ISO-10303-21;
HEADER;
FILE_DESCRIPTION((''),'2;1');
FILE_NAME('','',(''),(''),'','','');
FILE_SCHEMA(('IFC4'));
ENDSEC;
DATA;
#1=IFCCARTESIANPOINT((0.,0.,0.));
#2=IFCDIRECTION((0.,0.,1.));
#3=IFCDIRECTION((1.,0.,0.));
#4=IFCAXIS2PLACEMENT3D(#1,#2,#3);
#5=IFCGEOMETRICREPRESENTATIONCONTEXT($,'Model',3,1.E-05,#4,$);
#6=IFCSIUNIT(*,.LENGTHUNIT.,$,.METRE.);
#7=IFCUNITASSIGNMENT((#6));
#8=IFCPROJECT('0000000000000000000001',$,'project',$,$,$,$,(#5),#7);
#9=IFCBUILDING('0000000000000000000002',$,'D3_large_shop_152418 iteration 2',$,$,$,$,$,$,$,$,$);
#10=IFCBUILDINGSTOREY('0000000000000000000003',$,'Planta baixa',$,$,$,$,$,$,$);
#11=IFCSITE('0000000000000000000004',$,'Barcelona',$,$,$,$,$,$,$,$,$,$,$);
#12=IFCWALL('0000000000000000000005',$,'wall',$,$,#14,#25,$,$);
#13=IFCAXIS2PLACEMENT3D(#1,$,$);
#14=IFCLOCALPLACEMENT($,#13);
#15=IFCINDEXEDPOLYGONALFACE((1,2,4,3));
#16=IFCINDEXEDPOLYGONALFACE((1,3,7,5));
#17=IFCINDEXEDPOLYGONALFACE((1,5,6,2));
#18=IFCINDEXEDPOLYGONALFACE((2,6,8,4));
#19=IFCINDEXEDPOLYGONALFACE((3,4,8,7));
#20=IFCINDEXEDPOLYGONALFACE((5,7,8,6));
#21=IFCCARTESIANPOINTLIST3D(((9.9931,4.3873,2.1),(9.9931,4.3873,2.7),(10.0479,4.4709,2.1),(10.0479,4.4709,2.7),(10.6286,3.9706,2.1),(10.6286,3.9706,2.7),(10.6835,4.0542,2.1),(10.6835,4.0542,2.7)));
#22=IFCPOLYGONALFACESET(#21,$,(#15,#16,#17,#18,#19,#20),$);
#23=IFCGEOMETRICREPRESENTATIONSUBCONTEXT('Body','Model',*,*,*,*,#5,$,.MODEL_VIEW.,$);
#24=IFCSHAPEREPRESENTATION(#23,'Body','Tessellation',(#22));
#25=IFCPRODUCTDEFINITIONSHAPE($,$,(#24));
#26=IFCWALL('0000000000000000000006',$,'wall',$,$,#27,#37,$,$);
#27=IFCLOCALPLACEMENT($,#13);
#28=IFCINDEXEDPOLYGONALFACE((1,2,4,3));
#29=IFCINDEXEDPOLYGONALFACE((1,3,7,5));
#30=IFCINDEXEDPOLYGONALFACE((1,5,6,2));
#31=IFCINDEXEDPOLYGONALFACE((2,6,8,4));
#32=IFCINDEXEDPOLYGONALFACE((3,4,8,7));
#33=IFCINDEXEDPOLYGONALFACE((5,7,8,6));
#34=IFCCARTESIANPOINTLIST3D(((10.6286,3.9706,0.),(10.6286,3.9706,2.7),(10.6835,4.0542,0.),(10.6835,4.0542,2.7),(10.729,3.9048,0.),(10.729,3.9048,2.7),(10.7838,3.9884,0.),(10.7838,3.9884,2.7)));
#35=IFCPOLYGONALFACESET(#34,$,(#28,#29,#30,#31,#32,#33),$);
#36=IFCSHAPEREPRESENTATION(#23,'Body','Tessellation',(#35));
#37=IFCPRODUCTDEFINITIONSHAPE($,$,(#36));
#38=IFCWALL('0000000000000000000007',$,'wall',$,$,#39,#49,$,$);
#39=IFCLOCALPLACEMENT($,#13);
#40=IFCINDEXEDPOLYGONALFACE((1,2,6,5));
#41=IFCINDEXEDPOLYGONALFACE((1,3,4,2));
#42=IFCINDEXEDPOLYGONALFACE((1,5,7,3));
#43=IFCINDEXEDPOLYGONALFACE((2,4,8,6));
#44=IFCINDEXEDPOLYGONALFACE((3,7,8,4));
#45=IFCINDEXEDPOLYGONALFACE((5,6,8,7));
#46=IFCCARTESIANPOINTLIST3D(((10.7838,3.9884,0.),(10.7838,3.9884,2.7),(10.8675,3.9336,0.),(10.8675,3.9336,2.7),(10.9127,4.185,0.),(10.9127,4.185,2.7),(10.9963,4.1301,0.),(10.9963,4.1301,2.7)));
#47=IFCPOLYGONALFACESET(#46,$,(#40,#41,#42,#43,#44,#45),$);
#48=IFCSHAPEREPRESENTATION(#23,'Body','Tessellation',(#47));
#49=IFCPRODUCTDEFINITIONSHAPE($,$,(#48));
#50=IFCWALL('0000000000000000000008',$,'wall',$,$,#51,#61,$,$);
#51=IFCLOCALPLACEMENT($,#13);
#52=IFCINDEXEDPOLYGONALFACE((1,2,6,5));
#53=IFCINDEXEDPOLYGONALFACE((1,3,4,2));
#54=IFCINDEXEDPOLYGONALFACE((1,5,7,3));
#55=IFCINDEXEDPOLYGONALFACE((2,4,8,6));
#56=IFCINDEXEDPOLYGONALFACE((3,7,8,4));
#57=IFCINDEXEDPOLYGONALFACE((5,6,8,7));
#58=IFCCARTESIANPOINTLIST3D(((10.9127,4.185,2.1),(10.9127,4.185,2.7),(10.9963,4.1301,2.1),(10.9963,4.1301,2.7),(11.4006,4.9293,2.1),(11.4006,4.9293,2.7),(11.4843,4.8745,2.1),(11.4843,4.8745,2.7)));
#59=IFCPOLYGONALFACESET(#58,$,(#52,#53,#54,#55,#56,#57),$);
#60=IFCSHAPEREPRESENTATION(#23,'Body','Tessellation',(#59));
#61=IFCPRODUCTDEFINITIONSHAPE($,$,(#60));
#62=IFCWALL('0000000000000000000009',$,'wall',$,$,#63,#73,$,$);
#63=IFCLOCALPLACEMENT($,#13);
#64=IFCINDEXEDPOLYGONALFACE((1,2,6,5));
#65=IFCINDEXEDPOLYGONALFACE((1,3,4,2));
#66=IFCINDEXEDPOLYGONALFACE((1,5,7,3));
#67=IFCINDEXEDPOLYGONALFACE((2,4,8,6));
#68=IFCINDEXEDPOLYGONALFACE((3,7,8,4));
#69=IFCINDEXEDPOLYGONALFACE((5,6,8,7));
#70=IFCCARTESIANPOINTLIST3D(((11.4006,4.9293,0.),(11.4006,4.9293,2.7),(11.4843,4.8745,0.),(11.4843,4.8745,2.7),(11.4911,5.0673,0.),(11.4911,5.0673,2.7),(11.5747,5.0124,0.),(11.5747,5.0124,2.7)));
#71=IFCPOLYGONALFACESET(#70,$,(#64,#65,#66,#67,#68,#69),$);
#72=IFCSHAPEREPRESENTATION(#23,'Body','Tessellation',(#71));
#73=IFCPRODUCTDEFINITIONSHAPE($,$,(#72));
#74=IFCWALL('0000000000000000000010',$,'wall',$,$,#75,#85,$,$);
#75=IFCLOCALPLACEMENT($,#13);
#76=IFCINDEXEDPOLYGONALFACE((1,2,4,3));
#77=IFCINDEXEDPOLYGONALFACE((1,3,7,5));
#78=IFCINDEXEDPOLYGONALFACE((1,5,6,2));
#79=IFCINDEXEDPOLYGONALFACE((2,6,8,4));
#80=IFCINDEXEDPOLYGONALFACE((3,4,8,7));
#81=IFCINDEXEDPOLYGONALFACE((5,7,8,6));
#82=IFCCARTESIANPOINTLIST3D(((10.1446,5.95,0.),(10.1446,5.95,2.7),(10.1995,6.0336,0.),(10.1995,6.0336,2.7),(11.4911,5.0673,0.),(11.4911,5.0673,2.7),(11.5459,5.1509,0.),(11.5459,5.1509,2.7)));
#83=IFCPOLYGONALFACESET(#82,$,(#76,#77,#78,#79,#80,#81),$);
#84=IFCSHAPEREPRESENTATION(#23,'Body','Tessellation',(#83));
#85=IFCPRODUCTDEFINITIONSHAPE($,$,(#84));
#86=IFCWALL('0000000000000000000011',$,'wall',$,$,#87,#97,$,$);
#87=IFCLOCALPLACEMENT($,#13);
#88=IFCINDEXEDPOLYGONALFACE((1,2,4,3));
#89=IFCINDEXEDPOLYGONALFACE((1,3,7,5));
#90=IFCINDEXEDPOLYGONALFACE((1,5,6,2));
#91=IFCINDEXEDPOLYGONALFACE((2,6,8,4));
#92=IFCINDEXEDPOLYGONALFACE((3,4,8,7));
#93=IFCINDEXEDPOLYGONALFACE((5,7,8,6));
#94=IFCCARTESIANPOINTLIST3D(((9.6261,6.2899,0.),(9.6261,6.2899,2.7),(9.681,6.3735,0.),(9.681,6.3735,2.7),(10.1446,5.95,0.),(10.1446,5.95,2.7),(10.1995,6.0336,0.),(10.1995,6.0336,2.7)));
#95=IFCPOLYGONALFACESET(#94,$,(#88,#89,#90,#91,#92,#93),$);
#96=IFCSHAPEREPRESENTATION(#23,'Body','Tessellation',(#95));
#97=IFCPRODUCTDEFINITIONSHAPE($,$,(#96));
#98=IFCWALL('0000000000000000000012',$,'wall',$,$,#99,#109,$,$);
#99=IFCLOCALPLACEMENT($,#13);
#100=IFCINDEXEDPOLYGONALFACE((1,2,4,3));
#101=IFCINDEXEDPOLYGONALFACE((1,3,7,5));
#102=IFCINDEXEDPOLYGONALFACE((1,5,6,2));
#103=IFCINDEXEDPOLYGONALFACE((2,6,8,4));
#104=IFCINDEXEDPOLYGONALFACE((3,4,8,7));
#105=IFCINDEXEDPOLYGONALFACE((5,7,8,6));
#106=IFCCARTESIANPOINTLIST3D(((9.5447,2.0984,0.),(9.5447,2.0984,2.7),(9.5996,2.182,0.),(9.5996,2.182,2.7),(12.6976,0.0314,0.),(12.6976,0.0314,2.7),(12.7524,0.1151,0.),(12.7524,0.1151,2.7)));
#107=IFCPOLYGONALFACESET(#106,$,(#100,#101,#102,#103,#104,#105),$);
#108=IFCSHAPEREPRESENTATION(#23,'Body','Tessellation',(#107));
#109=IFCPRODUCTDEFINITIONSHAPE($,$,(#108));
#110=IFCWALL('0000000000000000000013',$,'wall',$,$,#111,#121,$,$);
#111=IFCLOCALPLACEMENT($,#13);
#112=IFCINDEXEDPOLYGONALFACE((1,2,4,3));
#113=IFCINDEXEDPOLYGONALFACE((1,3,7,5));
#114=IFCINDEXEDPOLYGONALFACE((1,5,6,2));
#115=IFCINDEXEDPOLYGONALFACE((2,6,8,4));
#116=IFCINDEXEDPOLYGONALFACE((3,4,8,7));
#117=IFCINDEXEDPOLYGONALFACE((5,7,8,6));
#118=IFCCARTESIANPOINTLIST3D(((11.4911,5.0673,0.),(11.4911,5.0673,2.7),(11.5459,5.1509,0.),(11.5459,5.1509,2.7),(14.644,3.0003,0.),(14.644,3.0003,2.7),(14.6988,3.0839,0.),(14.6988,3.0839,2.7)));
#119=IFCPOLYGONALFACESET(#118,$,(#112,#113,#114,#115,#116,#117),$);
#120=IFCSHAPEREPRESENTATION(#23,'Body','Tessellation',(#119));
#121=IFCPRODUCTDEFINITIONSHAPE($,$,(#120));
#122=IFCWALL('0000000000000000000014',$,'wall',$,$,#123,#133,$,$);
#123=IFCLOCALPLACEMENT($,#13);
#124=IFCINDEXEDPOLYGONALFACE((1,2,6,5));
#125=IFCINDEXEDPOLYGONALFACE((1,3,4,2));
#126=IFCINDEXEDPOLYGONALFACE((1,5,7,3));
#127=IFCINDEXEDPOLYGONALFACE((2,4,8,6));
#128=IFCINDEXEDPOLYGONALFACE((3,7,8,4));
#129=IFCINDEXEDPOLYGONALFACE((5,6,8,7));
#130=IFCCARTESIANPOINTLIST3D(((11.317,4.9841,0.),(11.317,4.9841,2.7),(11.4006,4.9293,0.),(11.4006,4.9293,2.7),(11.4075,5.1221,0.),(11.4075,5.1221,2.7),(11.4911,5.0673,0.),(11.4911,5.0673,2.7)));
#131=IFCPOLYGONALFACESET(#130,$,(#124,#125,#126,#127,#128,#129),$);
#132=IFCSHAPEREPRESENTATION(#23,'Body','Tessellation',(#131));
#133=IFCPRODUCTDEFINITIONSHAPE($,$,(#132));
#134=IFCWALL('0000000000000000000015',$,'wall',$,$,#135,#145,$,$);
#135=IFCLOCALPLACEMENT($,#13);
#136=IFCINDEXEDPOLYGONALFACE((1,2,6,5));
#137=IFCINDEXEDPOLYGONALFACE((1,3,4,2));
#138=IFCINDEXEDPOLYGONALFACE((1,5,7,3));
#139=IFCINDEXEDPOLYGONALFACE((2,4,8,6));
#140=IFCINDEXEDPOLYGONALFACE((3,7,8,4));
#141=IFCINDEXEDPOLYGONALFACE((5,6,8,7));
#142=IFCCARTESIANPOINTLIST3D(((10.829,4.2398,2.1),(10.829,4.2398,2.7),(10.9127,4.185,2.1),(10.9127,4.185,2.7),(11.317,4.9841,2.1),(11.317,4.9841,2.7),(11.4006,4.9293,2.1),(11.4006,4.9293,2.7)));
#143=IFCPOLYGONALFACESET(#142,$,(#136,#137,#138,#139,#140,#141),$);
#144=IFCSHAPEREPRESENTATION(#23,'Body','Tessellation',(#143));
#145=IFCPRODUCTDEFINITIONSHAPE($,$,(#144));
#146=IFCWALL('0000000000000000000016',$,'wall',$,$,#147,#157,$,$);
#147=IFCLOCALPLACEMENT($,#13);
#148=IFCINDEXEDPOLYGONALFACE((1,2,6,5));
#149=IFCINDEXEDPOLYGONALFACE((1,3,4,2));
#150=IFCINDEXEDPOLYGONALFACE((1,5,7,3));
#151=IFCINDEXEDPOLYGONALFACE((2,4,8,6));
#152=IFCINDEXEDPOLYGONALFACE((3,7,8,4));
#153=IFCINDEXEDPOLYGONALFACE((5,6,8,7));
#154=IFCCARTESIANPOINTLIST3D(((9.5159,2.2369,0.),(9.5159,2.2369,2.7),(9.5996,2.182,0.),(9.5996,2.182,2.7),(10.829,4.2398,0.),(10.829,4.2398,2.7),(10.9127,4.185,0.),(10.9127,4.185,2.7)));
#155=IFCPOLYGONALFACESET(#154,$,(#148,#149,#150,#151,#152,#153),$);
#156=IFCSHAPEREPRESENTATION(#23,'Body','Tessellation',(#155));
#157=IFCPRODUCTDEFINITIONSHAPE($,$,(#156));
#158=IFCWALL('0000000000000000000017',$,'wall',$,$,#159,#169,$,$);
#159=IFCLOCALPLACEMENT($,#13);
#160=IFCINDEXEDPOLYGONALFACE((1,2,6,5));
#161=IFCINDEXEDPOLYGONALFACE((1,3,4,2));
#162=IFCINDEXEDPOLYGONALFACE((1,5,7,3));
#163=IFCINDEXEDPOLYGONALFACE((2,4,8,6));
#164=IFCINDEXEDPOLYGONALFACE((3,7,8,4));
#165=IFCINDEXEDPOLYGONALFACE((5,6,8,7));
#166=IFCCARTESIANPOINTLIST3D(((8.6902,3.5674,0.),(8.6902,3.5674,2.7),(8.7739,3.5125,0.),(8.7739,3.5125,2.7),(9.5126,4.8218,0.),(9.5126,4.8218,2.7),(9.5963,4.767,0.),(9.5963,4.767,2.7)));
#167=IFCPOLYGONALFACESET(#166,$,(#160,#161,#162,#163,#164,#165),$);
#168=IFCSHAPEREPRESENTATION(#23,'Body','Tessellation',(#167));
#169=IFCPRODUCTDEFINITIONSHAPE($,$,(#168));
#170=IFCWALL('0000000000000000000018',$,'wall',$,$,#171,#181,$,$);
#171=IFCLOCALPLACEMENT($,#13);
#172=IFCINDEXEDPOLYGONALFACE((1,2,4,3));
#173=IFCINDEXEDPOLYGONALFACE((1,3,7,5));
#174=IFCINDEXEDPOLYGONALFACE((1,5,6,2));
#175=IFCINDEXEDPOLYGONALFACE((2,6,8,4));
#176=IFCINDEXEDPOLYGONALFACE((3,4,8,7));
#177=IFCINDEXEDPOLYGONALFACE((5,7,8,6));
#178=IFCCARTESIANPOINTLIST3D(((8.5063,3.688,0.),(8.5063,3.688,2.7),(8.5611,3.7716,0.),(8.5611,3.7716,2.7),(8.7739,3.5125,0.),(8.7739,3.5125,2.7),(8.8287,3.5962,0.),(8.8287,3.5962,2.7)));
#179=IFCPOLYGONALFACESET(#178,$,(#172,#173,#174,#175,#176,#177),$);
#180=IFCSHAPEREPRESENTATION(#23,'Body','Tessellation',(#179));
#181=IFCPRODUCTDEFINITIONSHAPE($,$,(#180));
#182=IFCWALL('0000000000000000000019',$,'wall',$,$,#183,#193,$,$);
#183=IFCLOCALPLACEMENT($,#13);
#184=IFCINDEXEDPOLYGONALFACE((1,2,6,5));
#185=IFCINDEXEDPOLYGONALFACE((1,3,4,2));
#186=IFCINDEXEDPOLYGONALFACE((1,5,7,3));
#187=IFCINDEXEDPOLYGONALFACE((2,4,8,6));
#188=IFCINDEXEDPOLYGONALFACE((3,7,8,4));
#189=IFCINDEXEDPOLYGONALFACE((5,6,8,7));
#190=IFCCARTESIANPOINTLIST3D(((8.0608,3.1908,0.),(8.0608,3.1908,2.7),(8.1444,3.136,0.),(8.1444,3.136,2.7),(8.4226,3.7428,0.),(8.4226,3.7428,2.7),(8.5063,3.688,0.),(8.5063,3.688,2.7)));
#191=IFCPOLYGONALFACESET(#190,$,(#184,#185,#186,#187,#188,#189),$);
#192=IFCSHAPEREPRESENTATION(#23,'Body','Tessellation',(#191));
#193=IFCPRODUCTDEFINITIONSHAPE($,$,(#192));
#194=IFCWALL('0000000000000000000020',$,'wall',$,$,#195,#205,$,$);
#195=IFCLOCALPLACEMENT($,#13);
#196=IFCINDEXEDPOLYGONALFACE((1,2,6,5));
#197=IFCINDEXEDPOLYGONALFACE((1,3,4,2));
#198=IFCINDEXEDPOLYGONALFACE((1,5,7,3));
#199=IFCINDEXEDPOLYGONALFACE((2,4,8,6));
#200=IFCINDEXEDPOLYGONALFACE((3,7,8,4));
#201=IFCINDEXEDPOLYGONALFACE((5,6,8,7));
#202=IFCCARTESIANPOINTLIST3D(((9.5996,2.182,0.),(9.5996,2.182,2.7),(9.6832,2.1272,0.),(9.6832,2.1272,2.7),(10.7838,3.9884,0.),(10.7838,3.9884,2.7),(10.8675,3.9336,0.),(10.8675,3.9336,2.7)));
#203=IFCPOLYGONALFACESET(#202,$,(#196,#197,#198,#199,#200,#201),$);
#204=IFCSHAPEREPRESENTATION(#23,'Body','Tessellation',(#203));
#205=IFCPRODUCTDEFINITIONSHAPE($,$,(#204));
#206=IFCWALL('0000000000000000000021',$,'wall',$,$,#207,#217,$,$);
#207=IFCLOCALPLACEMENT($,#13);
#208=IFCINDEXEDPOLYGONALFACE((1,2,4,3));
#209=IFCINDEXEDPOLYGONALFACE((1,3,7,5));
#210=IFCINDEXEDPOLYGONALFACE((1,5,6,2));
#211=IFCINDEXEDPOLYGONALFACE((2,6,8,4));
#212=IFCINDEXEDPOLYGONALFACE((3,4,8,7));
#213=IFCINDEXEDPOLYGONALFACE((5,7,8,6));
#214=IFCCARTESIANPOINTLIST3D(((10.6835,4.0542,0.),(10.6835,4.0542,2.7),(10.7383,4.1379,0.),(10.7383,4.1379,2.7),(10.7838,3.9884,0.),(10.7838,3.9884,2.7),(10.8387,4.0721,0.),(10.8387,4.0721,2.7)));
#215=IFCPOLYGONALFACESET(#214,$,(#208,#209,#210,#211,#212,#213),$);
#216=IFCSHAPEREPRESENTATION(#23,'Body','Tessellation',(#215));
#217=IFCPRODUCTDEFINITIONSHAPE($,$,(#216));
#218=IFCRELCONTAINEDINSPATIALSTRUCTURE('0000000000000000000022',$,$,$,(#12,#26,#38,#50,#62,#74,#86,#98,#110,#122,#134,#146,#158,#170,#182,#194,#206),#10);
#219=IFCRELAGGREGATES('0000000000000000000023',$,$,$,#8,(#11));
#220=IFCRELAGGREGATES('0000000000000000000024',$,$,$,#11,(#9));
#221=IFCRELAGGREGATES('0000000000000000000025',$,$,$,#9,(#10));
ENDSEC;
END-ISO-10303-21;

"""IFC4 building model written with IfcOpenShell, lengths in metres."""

from ifc_helpers import new_model, si_unit, frame, origin, origin_with_axes, place, context, subcontext, project, spatial, polyline, outline, extrude, element, save


model = new_model("IFC4")

# Units and contexts
model_context = context("Model", 3, precision=1e-05, world=origin_with_axes())
body_context = subcontext(model_context, "Body", "Model", "MODEL_VIEW")
ifc_project = project(units=[si_unit("LENGTHUNIT", "METRE")], contexts=[model_context])

# Site, building, storey
site = spatial("IfcSite", under=ifc_project, Name="Barcelona")
building = spatial("IfcBuilding", under=site, Name="D3_large_shop_152418 iteration 2")
storey = spatial("IfcBuildingStorey", under=building, Name="Planta baixa")

# Walls
wall_1_placement = place(None, origin_with_axes())
element("IfcWall", 1, at=wall_1_placement, inside=storey, Name="wall", context=body_context, shape_type="SweptSolid", body=[
    extrude(outline(polyline([(10.0479, 4.4709), (10.6835, 4.0542), (10.6286, 3.9706), (9.9931, 4.3873), (10.0479, 4.4709)])), frame((0.0, 0.0, 2.1)), (0.0, 0.0, 1.0), 0.6),
])
wall_2_placement = place(None, origin_with_axes())
element("IfcWall", 2, at=wall_2_placement, inside=storey, Name="wall", context=body_context, shape_type="SweptSolid", body=[
    extrude(outline(polyline([(10.6835, 4.0542), (10.7838, 3.9884), (10.729, 3.9048), (10.6286, 3.9706), (10.6835, 4.0542)])), origin(), (0.0, 0.0, 1.0), 2.7),
])
wall_3_placement = place(None, origin_with_axes())
element("IfcWall", 3, at=wall_3_placement, inside=storey, Name="wall", context=body_context, shape_type="SweptSolid", body=[
    extrude(outline(polyline([(10.7838, 3.9884), (10.9127, 4.185), (10.9963, 4.1301), (10.8675, 3.9336), (10.7838, 3.9884)])), origin(), (0.0, 0.0, 1.0), 2.7),
])
wall_4_placement = place(None, origin_with_axes())
element("IfcWall", 4, at=wall_4_placement, inside=storey, Name="wall", context=body_context, shape_type="SweptSolid", body=[
    extrude(outline(polyline([(10.9127, 4.185), (11.4006, 4.9293), (11.4843, 4.8745), (10.9963, 4.1301), (10.9127, 4.185)])), frame((0.0, 0.0, 2.1)), (0.0, 0.0, 1.0), 0.6),
])
wall_5_placement = place(None, origin_with_axes())
element("IfcWall", 5, at=wall_5_placement, inside=storey, Name="wall", context=body_context, shape_type="SweptSolid", body=[
    extrude(outline(polyline([(11.4006, 4.9293), (11.4911, 5.0673), (11.5747, 5.0124), (11.4843, 4.8745), (11.4006, 4.9293)])), origin(), (0.0, 0.0, 1.0), 2.7),
])
wall_6_placement = place(None, origin_with_axes())
element("IfcWall", 6, at=wall_6_placement, inside=storey, Name="wall", context=body_context, shape_type="SweptSolid", body=[
    extrude(outline(polyline([(11.4911, 5.0673), (10.1446, 5.95), (10.1995, 6.0336), (11.5459, 5.1509), (11.4911, 5.0673)])), origin(), (0.0, 0.0, 1.0), 2.7),
])
wall_7_placement = place(None, origin_with_axes())
element("IfcWall", 7, at=wall_7_placement, inside=storey, Name="wall", context=body_context, shape_type="SweptSolid", body=[
    extrude(outline(polyline([(10.1446, 5.95), (9.6261, 6.2899), (9.681, 6.3735), (10.1995, 6.0336), (10.1446, 5.95)])), origin(), (0.0, 0.0, 1.0), 2.7),
])
wall_8_placement = place(None, origin_with_axes())
element("IfcWall", 8, at=wall_8_placement, inside=storey, Name="wall", context=body_context, shape_type="SweptSolid", body=[
    extrude(outline(polyline([(9.5996, 2.182), (12.7524, 0.1151), (12.6976, 0.0314), (9.5447, 2.0984), (9.5996, 2.182)])), origin(), (0.0, 0.0, 1.0), 2.7),
])
wall_9_placement = place(None, origin_with_axes())
element("IfcWall", 9, at=wall_9_placement, inside=storey, Name="wall", context=body_context, shape_type="SweptSolid", body=[
    extrude(outline(polyline([(14.644, 3.0003), (11.4911, 5.0673), (11.5459, 5.1509), (14.6988, 3.0839), (14.644, 3.0003)])), origin(), (0.0, 0.0, 1.0), 2.7),
])
wall_10_placement = place(None, origin_with_axes())
element("IfcWall", 10, at=wall_10_placement, inside=storey, Name="wall", context=body_context, shape_type="SweptSolid", body=[
    extrude(outline(polyline([(11.4911, 5.0673), (11.4006, 4.9293), (11.317, 4.9841), (11.4075, 5.1221), (11.4911, 5.0673)])), origin(), (0.0, 0.0, 1.0), 2.7),
])
wall_11_placement = place(None, origin_with_axes())
element("IfcWall", 11, at=wall_11_placement, inside=storey, Name="wall", context=body_context, shape_type="SweptSolid", body=[
    extrude(outline(polyline([(11.4006, 4.9293), (10.9127, 4.185), (10.829, 4.2398), (11.317, 4.9841), (11.4006, 4.9293)])), frame((0.0, 0.0, 2.1)), (0.0, 0.0, 1.0), 0.6),
])
wall_12_placement = place(None, origin_with_axes())
element("IfcWall", 12, at=wall_12_placement, inside=storey, Name="wall", context=body_context, shape_type="SweptSolid", body=[
    extrude(outline(polyline([(10.9127, 4.185), (9.5996, 2.182), (9.5159, 2.2369), (10.829, 4.2398), (10.9127, 4.185)])), origin(), (0.0, 0.0, 1.0), 2.7),
])
wall_13_placement = place(None, origin_with_axes())
element("IfcWall", 13, at=wall_13_placement, inside=storey, Name="wall", context=body_context, shape_type="SweptSolid", body=[
    extrude(outline(polyline([(9.5963, 4.767), (8.7739, 3.5125), (8.6902, 3.5674), (9.5126, 4.8218), (9.5963, 4.767)])), origin(), (0.0, 0.0, 1.0), 2.7),
])
wall_14_placement = place(None, origin_with_axes())
element("IfcWall", 14, at=wall_14_placement, inside=storey, Name="wall", context=body_context, shape_type="SweptSolid", body=[
    extrude(outline(polyline([(8.7739, 3.5125), (8.5063, 3.688), (8.5611, 3.7716), (8.8287, 3.5962), (8.7739, 3.5125)])), origin(), (0.0, 0.0, 1.0), 2.7),
])
wall_15_placement = place(None, origin_with_axes())
element("IfcWall", 15, at=wall_15_placement, inside=storey, Name="wall", context=body_context, shape_type="SweptSolid", body=[
    extrude(outline(polyline([(8.5063, 3.688), (8.1444, 3.136), (8.0608, 3.1908), (8.4226, 3.7428), (8.5063, 3.688)])), origin(), (0.0, 0.0, 1.0), 2.7),
])
wall_16_placement = place(None, origin_with_axes())
element("IfcWall", 16, at=wall_16_placement, inside=storey, Name="wall", context=body_context, shape_type="SweptSolid", body=[
    extrude(outline(polyline([(9.5996, 2.182), (10.7838, 3.9884), (10.8675, 3.9336), (9.6832, 2.1272), (9.5996, 2.182)])), origin(), (0.0, 0.0, 1.0), 2.7),
])
wall_17_placement = place(None, origin_with_axes())
element("IfcWall", 17, at=wall_17_placement, inside=storey, Name="wall", context=body_context, shape_type="SweptSolid", body=[
    extrude(outline(polyline([(10.7838, 3.9884), (10.6835, 4.0542), (10.7383, 4.1379), (10.8387, 4.0721), (10.7838, 3.9884)])), origin(), (0.0, 0.0, 1.0), 2.7),
])

save(model, "model.ifc")
